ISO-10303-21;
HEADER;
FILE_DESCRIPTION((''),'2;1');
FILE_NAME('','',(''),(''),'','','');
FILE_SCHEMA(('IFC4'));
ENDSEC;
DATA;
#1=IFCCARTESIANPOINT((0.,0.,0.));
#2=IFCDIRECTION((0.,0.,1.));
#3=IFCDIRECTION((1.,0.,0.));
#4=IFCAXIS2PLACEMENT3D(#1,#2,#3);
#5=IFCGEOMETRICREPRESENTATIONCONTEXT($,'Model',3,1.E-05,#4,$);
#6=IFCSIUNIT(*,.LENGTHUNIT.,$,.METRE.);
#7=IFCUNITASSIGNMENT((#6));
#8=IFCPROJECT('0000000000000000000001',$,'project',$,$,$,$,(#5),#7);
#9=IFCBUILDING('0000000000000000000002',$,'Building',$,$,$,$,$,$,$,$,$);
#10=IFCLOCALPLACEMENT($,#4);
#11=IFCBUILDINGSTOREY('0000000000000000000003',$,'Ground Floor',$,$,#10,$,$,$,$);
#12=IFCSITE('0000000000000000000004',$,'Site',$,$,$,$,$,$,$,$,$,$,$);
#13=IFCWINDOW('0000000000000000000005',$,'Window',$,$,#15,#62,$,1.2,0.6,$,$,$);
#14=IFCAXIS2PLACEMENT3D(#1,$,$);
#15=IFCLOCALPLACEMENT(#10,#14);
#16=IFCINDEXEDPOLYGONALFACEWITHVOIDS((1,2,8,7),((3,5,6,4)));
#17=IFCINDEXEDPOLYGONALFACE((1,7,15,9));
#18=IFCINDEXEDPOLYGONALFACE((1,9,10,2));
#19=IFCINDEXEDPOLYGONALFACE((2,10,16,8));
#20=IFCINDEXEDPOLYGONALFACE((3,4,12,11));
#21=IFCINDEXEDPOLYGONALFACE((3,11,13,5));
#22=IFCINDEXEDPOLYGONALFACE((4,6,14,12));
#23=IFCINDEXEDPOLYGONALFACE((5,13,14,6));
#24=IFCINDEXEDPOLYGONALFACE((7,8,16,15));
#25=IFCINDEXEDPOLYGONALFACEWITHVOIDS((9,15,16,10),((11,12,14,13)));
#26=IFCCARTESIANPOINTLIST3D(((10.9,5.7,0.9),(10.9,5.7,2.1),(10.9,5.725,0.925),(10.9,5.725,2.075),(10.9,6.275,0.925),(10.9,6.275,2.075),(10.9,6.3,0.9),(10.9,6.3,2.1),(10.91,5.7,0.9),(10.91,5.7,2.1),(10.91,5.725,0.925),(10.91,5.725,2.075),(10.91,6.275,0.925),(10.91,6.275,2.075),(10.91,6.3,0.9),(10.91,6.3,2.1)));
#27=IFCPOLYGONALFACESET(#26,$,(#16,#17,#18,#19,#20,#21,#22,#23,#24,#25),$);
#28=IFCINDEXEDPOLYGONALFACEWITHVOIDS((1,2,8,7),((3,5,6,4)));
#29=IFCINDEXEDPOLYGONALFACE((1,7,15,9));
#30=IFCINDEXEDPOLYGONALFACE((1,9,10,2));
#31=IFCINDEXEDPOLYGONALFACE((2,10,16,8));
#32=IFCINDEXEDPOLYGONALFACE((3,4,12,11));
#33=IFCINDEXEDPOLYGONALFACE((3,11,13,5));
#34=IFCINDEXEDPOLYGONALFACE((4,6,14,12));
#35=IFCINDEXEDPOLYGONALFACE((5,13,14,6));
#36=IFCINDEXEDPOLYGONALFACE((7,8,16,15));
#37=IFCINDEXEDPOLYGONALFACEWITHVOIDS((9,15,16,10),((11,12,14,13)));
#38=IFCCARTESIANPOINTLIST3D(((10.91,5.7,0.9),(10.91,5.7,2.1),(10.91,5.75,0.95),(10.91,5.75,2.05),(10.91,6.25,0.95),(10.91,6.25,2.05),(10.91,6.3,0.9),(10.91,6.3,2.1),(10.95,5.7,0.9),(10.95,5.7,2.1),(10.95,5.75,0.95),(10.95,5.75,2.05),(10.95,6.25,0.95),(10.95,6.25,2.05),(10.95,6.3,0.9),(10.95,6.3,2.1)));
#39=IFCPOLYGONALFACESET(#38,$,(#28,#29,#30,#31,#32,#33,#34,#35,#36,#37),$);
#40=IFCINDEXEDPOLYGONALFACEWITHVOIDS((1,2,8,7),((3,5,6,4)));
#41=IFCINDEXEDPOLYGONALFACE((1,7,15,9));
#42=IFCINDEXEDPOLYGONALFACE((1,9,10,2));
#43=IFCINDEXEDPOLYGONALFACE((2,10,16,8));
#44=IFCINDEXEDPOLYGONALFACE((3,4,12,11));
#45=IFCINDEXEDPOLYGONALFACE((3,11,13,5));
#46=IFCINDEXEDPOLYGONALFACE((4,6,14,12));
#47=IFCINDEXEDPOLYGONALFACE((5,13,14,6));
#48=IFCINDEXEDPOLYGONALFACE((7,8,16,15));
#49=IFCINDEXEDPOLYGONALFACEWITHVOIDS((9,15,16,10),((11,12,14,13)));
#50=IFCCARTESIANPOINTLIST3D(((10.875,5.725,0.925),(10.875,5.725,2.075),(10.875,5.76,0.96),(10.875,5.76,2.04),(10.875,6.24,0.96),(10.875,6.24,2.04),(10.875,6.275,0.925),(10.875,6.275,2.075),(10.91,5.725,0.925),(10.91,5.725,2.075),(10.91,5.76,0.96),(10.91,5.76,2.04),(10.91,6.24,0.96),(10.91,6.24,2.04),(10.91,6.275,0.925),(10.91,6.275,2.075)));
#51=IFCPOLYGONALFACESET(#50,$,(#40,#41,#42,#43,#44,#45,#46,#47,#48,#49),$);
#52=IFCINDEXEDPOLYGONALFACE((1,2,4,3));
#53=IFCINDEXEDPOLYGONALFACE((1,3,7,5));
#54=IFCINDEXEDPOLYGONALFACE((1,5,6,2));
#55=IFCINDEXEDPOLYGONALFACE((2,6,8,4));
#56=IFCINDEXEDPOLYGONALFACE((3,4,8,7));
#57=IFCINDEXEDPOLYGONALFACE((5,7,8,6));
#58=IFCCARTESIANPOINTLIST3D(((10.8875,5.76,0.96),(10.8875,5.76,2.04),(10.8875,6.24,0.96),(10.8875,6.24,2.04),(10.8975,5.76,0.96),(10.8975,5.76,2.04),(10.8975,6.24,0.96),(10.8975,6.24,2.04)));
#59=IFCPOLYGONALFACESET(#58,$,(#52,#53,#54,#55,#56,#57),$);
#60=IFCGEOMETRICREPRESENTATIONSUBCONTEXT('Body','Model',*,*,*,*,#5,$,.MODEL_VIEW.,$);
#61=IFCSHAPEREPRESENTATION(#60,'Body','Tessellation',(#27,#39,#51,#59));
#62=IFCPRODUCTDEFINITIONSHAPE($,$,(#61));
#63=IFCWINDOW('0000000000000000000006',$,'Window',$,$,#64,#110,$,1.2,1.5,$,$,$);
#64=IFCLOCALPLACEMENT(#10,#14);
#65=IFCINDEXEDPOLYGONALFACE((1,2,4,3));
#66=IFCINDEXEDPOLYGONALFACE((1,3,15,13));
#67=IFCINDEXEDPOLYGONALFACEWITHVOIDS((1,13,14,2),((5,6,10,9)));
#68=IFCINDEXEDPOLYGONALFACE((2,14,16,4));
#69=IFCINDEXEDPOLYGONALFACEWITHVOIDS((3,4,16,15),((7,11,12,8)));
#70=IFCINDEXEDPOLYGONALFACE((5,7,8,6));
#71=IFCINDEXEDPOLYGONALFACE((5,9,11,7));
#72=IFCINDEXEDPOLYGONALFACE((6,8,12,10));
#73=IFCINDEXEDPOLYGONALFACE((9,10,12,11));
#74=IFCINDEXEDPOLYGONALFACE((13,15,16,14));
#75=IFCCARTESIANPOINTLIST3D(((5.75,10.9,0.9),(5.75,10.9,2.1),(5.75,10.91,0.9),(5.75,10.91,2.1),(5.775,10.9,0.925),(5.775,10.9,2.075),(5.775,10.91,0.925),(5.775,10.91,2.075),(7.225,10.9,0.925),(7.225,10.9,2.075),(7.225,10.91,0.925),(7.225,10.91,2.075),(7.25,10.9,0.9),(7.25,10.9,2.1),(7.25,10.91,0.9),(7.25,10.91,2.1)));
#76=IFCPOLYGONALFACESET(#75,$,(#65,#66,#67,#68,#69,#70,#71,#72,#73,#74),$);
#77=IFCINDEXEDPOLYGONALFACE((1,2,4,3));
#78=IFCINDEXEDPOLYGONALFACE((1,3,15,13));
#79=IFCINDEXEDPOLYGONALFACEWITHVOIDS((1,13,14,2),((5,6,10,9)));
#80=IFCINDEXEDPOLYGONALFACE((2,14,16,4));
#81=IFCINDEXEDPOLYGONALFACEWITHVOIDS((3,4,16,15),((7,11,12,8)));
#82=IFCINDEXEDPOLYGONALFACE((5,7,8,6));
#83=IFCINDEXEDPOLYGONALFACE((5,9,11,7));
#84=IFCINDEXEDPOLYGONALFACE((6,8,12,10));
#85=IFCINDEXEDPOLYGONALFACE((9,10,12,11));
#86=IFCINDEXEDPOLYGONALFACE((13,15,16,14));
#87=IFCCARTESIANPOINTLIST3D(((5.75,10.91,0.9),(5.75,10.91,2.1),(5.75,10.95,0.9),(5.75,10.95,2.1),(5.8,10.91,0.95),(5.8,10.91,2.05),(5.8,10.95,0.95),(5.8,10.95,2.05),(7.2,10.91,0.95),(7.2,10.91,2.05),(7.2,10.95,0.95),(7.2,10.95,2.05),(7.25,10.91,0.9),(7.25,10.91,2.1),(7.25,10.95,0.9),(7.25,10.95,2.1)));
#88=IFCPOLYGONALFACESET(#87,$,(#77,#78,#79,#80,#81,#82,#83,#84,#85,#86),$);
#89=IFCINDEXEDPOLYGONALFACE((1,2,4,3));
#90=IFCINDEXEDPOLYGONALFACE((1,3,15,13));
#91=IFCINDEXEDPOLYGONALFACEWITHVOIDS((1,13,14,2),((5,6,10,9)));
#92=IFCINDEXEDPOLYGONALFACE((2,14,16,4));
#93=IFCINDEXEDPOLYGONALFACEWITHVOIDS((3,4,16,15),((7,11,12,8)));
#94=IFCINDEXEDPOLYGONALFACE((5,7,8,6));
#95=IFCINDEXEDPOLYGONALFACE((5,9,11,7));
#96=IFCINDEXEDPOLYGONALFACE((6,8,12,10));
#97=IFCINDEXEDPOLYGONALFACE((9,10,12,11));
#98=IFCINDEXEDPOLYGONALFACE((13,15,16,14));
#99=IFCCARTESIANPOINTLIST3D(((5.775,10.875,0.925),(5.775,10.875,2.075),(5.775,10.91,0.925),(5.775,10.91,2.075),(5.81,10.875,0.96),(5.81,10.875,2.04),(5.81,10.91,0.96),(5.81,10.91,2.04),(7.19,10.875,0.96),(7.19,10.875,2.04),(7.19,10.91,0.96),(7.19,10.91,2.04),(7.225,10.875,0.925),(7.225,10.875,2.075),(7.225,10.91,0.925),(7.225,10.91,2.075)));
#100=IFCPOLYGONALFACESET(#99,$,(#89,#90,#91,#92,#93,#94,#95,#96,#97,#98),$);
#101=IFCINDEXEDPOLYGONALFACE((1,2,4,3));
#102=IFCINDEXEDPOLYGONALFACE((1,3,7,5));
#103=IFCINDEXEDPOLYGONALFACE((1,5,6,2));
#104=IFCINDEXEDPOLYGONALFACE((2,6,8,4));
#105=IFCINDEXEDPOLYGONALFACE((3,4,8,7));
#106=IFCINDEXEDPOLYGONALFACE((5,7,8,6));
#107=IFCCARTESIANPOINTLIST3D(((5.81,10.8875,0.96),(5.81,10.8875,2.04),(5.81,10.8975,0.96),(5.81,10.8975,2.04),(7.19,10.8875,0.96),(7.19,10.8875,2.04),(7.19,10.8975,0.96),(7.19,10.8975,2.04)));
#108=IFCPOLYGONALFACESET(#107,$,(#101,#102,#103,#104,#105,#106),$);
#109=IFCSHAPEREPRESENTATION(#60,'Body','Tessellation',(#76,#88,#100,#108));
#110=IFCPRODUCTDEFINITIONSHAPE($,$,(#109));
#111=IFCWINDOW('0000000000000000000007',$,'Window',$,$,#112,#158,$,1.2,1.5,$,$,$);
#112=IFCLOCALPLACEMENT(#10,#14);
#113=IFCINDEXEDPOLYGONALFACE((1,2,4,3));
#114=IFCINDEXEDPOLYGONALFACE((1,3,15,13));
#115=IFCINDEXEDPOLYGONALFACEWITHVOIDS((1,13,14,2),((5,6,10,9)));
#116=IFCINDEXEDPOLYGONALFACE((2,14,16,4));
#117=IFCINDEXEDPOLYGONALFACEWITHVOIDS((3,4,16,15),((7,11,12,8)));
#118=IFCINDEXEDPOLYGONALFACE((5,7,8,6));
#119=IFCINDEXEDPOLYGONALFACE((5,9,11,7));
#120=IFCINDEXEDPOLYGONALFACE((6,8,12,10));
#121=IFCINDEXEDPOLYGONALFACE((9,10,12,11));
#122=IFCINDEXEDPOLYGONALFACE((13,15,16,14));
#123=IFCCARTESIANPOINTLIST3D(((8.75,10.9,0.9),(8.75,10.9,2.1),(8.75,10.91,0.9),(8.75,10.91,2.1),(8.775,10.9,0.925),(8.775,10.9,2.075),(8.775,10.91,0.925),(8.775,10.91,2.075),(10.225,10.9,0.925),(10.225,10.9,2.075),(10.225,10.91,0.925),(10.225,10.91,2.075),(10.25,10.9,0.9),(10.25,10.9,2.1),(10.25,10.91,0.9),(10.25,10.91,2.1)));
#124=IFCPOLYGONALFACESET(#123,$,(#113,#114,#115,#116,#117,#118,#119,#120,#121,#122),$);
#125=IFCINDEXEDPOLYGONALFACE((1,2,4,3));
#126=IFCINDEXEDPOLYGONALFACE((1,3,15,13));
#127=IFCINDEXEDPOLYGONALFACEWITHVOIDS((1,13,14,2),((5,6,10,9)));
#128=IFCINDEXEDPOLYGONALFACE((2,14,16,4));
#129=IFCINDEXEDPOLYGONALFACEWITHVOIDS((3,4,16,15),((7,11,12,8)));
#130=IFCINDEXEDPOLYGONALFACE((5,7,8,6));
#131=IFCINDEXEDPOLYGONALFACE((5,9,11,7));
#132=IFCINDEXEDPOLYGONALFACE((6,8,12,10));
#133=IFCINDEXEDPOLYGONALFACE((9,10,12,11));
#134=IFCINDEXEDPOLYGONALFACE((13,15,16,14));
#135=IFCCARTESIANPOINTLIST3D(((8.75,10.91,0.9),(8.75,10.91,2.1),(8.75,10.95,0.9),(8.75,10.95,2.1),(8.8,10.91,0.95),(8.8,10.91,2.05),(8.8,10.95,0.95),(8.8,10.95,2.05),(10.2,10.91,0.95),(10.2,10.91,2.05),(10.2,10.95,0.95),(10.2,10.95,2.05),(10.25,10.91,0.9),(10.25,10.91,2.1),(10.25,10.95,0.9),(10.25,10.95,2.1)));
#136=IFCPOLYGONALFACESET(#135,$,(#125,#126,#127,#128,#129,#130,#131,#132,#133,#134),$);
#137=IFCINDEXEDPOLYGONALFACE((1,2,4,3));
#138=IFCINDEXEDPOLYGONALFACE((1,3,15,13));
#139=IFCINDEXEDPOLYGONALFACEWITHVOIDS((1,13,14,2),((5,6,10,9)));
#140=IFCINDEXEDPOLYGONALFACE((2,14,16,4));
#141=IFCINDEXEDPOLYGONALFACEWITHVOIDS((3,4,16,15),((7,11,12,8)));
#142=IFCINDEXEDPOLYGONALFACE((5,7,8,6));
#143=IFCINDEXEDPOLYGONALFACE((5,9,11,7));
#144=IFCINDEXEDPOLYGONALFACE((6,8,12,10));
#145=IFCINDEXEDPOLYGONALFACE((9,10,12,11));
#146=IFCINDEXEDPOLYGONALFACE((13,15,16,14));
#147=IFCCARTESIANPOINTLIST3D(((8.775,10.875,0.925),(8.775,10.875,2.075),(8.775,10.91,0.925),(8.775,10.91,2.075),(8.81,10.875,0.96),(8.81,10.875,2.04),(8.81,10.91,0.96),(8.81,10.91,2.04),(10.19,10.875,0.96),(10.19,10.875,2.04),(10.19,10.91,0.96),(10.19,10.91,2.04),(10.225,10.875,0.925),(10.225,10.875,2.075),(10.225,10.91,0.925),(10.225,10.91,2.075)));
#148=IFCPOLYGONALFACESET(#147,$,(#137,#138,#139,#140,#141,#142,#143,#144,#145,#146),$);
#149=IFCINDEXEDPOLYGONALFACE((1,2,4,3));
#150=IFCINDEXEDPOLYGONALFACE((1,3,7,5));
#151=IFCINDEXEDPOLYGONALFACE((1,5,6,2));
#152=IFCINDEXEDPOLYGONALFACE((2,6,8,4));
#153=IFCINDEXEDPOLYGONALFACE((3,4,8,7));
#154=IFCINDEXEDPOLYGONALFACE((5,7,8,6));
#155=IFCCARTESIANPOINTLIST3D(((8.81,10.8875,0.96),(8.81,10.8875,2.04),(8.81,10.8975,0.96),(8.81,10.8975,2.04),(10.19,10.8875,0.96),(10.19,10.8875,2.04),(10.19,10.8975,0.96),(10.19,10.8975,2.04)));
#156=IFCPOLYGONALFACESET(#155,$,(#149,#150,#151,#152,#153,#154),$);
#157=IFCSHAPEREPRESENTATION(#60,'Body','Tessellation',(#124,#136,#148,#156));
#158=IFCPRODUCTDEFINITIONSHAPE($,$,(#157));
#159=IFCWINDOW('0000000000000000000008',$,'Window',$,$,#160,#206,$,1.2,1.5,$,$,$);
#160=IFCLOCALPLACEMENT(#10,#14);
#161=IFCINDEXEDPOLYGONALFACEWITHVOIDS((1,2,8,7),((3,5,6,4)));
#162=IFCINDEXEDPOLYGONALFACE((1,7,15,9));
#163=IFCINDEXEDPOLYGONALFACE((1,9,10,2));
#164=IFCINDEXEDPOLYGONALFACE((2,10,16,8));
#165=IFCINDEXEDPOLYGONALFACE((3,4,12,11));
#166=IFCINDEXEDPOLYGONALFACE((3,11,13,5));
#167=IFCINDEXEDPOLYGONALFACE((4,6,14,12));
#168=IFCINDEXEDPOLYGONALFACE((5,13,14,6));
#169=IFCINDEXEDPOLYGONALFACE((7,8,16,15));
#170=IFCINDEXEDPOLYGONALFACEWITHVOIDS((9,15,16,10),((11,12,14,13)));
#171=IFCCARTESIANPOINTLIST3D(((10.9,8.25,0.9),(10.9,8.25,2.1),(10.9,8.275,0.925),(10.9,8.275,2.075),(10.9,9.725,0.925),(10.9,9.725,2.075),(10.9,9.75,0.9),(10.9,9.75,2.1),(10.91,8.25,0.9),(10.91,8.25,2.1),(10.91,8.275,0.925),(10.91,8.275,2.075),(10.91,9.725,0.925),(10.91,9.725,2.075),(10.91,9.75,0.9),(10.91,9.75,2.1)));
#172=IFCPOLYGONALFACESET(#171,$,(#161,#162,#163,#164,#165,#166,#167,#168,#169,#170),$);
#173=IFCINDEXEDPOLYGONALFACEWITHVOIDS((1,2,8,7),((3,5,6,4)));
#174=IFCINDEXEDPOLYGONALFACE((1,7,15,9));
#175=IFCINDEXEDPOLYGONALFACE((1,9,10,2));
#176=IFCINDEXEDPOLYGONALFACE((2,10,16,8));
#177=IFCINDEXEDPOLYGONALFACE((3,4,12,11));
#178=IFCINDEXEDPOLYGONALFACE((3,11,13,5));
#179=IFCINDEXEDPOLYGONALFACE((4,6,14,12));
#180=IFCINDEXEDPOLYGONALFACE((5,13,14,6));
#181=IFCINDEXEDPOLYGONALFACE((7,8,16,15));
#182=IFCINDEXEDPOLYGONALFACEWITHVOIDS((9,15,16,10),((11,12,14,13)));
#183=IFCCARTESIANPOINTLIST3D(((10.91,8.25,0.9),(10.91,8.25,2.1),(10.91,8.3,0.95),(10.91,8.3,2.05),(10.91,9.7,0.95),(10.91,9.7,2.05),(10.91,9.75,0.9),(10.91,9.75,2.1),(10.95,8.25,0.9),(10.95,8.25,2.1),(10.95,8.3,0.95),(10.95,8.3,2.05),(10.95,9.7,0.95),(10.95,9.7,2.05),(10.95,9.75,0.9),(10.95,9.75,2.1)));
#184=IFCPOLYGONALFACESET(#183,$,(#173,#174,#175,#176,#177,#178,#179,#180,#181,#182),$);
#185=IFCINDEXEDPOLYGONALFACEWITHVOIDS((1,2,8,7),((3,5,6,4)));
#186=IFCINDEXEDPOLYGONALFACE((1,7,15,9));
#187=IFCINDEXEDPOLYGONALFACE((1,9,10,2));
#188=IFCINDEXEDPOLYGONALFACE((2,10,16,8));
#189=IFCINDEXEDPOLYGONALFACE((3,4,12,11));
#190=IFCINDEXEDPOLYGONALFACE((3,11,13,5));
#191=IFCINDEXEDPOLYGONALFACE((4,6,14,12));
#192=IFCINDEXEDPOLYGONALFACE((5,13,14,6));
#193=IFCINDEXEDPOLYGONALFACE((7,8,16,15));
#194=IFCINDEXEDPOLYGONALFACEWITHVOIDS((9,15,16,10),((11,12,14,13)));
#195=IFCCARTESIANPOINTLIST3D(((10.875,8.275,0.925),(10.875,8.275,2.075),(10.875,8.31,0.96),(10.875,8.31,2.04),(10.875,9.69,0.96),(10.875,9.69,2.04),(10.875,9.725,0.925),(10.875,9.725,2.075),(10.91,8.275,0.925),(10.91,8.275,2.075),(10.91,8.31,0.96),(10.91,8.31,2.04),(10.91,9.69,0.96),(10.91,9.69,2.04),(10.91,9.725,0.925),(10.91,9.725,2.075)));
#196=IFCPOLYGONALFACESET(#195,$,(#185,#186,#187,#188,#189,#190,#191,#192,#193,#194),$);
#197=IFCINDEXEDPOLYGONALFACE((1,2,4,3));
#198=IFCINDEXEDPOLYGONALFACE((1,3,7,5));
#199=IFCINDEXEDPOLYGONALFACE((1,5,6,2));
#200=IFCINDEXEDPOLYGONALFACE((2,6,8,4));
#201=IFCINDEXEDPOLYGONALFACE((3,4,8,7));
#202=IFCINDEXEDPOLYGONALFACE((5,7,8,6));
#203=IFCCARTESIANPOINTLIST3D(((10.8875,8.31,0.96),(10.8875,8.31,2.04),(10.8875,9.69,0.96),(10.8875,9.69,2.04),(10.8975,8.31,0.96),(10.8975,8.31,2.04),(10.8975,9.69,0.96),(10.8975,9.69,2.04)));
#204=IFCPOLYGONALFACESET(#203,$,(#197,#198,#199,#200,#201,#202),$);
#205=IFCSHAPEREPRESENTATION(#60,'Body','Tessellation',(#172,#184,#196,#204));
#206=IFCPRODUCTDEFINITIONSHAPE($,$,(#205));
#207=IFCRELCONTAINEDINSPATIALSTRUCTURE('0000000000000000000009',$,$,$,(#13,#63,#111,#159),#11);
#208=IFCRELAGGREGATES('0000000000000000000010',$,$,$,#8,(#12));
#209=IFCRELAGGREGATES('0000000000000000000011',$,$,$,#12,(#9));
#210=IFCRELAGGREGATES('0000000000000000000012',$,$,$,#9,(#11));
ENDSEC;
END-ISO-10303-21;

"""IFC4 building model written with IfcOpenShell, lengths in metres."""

from ifc_helpers import new_model, si_unit, frame, origin_with_axes, place, context, subcontext, project, spatial, line, indexed_curve, outline, extrude, element, save


model = new_model("IFC4")

# Units and contexts
model_context = context("Model", 3, precision=1e-05, world=origin_with_axes())
body_context = subcontext(model_context, "Body", "Model", "MODEL_VIEW")
ifc_project = project(units=[si_unit("LENGTHUNIT", "METRE")], contexts=[model_context])

# Site, building, storey
site = spatial("IfcSite", under=ifc_project, Name="Site")
building = spatial("IfcBuilding", under=site, Name="Building")
storey_placement = place(None, origin_with_axes())
storey = spatial("IfcBuildingStorey", under=building, at=storey_placement, Name="Ground Floor")

# Windows
window_1_placement = place(storey_placement, frame((11.0, 5.7, 0.9), z_axis=(0.0, 0.0, 1.0), x_axis=(0.0, 1.0, 0.0)))
element("IfcWindow", 1, at=window_1_placement, inside=storey, Name="Window", OverallHeight=1.2, OverallWidth=0.6, context=body_context, shape_type="SweptSolid", body=[
    extrude(outline(indexed_curve([(0.0, 0.0), (0.6, 0.0), (0.6, 1.2), (0.0, 1.2)], segments=[line(1, 2, 3, 4, 1)]), holes=[indexed_curve([(0.025, 0.025), (0.575, 0.025), (0.575, 1.175), (0.025, 1.175)], segments=[line(1, 2, 3, 4, 1)])]), frame((0.0, 0.09, 0.0), z_axis=(0.0, -1.0, 0.0), x_axis=(1.0, 0.0, 0.0)), (0.0, 0.0, -1.0), 0.01),
    extrude(outline(indexed_curve([(0.0, 0.0), (0.6, 0.0), (0.6, 1.2), (0.0, 1.2)], segments=[line(1, 2, 3, 4, 1)]), holes=[indexed_curve([(0.05, 0.05), (0.55, 0.05), (0.55, 1.15), (0.05, 1.15)], segments=[line(1, 2, 3, 4, 1)])]), frame((0.0, 0.05, 0.0), z_axis=(0.0, -1.0, 0.0), x_axis=(1.0, 0.0, 0.0)), (0.0, 0.0, -1.0), 0.04),
    extrude(outline(indexed_curve([(0.0, 0.0), (0.55, 0.0), (0.55, 1.15), (0.0, 1.15)], segments=[line(1, 2, 3, 4, 1)]), holes=[indexed_curve([(0.035, 0.035), (0.515, 0.035), (0.515, 1.115), (0.035, 1.115)], segments=[line(1, 2, 3, 4, 1)])]), frame((0.025, 0.09, 0.025), z_axis=(0.0, -1.0, 0.0), x_axis=(1.0, 0.0, 0.0)), (0.0, 0.0, -1.0), 0.035),
    extrude(outline(indexed_curve([(0.035, 0.035), (0.515, 0.035), (0.515, 1.115), (0.035, 1.115)], segments=[line(1, 2, 3, 4, 1)])), frame((0.025, 0.1025, 0.025), z_axis=(0.0, -1.0, 0.0), x_axis=(1.0, 0.0, 0.0)), (0.0, 0.0, -1.0), 0.01),
])
for number, where, z_axis, x_axis, name in (
    (2, (7.25, 11.0, 0.9), (0.0, 0.0, 1.0), (-1.0, 0.0, 0.0), "Window"),
    (3, (10.25, 11.0, 0.9), (0.0, 0.0, 1.0), (-1.0, 0.0, 0.0), "Window"),
    (4, (11.0, 8.25, 0.9), (0.0, 0.0, 1.0), (0.0, 1.0, 0.0), "Window"),
):
    element("IfcWindow", number, at=place(storey_placement, frame(where, z_axis=z_axis, x_axis=x_axis)), inside=storey, Name=name, OverallHeight=1.2, OverallWidth=1.5, context=body_context, shape_type="SweptSolid", body=[
        extrude(outline(indexed_curve([(0.0, 0.0), (1.5, 0.0), (1.5, 1.2), (0.0, 1.2)], segments=[line(1, 2, 3, 4, 1)]), holes=[indexed_curve([(0.025, 0.025), (1.475, 0.025), (1.475, 1.175), (0.025, 1.175)], segments=[line(1, 2, 3, 4, 1)])]), frame((0.0, 0.09, 0.0), z_axis=(0.0, -1.0, 0.0), x_axis=(1.0, 0.0, 0.0)), (0.0, 0.0, -1.0), 0.01),
        extrude(outline(indexed_curve([(0.0, 0.0), (1.5, 0.0), (1.5, 1.2), (0.0, 1.2)], segments=[line(1, 2, 3, 4, 1)]), holes=[indexed_curve([(0.05, 0.05), (1.45, 0.05), (1.45, 1.15), (0.05, 1.15)], segments=[line(1, 2, 3, 4, 1)])]), frame((0.0, 0.05, 0.0), z_axis=(0.0, -1.0, 0.0), x_axis=(1.0, 0.0, 0.0)), (0.0, 0.0, -1.0), 0.04),
        extrude(outline(indexed_curve([(0.0, 0.0), (1.45, 0.0), (1.45, 1.15), (0.0, 1.15)], segments=[line(1, 2, 3, 4, 1)]), holes=[indexed_curve([(0.035, 0.035), (1.415, 0.035), (1.415, 1.115), (0.035, 1.115)], segments=[line(1, 2, 3, 4, 1)])]), frame((0.025, 0.09, 0.025), z_axis=(0.0, -1.0, 0.0), x_axis=(1.0, 0.0, 0.0)), (0.0, 0.0, -1.0), 0.035),
        extrude(outline(indexed_curve([(0.035, 0.035), (1.415, 0.035), (1.415, 1.115), (0.035, 1.115)], segments=[line(1, 2, 3, 4, 1)])), frame((0.025, 0.1025, 0.025), z_axis=(0.0, -1.0, 0.0), x_axis=(1.0, 0.0, 0.0)), (0.0, 0.0, -1.0), 0.01),
    ])

save(model, "model.ifc")
